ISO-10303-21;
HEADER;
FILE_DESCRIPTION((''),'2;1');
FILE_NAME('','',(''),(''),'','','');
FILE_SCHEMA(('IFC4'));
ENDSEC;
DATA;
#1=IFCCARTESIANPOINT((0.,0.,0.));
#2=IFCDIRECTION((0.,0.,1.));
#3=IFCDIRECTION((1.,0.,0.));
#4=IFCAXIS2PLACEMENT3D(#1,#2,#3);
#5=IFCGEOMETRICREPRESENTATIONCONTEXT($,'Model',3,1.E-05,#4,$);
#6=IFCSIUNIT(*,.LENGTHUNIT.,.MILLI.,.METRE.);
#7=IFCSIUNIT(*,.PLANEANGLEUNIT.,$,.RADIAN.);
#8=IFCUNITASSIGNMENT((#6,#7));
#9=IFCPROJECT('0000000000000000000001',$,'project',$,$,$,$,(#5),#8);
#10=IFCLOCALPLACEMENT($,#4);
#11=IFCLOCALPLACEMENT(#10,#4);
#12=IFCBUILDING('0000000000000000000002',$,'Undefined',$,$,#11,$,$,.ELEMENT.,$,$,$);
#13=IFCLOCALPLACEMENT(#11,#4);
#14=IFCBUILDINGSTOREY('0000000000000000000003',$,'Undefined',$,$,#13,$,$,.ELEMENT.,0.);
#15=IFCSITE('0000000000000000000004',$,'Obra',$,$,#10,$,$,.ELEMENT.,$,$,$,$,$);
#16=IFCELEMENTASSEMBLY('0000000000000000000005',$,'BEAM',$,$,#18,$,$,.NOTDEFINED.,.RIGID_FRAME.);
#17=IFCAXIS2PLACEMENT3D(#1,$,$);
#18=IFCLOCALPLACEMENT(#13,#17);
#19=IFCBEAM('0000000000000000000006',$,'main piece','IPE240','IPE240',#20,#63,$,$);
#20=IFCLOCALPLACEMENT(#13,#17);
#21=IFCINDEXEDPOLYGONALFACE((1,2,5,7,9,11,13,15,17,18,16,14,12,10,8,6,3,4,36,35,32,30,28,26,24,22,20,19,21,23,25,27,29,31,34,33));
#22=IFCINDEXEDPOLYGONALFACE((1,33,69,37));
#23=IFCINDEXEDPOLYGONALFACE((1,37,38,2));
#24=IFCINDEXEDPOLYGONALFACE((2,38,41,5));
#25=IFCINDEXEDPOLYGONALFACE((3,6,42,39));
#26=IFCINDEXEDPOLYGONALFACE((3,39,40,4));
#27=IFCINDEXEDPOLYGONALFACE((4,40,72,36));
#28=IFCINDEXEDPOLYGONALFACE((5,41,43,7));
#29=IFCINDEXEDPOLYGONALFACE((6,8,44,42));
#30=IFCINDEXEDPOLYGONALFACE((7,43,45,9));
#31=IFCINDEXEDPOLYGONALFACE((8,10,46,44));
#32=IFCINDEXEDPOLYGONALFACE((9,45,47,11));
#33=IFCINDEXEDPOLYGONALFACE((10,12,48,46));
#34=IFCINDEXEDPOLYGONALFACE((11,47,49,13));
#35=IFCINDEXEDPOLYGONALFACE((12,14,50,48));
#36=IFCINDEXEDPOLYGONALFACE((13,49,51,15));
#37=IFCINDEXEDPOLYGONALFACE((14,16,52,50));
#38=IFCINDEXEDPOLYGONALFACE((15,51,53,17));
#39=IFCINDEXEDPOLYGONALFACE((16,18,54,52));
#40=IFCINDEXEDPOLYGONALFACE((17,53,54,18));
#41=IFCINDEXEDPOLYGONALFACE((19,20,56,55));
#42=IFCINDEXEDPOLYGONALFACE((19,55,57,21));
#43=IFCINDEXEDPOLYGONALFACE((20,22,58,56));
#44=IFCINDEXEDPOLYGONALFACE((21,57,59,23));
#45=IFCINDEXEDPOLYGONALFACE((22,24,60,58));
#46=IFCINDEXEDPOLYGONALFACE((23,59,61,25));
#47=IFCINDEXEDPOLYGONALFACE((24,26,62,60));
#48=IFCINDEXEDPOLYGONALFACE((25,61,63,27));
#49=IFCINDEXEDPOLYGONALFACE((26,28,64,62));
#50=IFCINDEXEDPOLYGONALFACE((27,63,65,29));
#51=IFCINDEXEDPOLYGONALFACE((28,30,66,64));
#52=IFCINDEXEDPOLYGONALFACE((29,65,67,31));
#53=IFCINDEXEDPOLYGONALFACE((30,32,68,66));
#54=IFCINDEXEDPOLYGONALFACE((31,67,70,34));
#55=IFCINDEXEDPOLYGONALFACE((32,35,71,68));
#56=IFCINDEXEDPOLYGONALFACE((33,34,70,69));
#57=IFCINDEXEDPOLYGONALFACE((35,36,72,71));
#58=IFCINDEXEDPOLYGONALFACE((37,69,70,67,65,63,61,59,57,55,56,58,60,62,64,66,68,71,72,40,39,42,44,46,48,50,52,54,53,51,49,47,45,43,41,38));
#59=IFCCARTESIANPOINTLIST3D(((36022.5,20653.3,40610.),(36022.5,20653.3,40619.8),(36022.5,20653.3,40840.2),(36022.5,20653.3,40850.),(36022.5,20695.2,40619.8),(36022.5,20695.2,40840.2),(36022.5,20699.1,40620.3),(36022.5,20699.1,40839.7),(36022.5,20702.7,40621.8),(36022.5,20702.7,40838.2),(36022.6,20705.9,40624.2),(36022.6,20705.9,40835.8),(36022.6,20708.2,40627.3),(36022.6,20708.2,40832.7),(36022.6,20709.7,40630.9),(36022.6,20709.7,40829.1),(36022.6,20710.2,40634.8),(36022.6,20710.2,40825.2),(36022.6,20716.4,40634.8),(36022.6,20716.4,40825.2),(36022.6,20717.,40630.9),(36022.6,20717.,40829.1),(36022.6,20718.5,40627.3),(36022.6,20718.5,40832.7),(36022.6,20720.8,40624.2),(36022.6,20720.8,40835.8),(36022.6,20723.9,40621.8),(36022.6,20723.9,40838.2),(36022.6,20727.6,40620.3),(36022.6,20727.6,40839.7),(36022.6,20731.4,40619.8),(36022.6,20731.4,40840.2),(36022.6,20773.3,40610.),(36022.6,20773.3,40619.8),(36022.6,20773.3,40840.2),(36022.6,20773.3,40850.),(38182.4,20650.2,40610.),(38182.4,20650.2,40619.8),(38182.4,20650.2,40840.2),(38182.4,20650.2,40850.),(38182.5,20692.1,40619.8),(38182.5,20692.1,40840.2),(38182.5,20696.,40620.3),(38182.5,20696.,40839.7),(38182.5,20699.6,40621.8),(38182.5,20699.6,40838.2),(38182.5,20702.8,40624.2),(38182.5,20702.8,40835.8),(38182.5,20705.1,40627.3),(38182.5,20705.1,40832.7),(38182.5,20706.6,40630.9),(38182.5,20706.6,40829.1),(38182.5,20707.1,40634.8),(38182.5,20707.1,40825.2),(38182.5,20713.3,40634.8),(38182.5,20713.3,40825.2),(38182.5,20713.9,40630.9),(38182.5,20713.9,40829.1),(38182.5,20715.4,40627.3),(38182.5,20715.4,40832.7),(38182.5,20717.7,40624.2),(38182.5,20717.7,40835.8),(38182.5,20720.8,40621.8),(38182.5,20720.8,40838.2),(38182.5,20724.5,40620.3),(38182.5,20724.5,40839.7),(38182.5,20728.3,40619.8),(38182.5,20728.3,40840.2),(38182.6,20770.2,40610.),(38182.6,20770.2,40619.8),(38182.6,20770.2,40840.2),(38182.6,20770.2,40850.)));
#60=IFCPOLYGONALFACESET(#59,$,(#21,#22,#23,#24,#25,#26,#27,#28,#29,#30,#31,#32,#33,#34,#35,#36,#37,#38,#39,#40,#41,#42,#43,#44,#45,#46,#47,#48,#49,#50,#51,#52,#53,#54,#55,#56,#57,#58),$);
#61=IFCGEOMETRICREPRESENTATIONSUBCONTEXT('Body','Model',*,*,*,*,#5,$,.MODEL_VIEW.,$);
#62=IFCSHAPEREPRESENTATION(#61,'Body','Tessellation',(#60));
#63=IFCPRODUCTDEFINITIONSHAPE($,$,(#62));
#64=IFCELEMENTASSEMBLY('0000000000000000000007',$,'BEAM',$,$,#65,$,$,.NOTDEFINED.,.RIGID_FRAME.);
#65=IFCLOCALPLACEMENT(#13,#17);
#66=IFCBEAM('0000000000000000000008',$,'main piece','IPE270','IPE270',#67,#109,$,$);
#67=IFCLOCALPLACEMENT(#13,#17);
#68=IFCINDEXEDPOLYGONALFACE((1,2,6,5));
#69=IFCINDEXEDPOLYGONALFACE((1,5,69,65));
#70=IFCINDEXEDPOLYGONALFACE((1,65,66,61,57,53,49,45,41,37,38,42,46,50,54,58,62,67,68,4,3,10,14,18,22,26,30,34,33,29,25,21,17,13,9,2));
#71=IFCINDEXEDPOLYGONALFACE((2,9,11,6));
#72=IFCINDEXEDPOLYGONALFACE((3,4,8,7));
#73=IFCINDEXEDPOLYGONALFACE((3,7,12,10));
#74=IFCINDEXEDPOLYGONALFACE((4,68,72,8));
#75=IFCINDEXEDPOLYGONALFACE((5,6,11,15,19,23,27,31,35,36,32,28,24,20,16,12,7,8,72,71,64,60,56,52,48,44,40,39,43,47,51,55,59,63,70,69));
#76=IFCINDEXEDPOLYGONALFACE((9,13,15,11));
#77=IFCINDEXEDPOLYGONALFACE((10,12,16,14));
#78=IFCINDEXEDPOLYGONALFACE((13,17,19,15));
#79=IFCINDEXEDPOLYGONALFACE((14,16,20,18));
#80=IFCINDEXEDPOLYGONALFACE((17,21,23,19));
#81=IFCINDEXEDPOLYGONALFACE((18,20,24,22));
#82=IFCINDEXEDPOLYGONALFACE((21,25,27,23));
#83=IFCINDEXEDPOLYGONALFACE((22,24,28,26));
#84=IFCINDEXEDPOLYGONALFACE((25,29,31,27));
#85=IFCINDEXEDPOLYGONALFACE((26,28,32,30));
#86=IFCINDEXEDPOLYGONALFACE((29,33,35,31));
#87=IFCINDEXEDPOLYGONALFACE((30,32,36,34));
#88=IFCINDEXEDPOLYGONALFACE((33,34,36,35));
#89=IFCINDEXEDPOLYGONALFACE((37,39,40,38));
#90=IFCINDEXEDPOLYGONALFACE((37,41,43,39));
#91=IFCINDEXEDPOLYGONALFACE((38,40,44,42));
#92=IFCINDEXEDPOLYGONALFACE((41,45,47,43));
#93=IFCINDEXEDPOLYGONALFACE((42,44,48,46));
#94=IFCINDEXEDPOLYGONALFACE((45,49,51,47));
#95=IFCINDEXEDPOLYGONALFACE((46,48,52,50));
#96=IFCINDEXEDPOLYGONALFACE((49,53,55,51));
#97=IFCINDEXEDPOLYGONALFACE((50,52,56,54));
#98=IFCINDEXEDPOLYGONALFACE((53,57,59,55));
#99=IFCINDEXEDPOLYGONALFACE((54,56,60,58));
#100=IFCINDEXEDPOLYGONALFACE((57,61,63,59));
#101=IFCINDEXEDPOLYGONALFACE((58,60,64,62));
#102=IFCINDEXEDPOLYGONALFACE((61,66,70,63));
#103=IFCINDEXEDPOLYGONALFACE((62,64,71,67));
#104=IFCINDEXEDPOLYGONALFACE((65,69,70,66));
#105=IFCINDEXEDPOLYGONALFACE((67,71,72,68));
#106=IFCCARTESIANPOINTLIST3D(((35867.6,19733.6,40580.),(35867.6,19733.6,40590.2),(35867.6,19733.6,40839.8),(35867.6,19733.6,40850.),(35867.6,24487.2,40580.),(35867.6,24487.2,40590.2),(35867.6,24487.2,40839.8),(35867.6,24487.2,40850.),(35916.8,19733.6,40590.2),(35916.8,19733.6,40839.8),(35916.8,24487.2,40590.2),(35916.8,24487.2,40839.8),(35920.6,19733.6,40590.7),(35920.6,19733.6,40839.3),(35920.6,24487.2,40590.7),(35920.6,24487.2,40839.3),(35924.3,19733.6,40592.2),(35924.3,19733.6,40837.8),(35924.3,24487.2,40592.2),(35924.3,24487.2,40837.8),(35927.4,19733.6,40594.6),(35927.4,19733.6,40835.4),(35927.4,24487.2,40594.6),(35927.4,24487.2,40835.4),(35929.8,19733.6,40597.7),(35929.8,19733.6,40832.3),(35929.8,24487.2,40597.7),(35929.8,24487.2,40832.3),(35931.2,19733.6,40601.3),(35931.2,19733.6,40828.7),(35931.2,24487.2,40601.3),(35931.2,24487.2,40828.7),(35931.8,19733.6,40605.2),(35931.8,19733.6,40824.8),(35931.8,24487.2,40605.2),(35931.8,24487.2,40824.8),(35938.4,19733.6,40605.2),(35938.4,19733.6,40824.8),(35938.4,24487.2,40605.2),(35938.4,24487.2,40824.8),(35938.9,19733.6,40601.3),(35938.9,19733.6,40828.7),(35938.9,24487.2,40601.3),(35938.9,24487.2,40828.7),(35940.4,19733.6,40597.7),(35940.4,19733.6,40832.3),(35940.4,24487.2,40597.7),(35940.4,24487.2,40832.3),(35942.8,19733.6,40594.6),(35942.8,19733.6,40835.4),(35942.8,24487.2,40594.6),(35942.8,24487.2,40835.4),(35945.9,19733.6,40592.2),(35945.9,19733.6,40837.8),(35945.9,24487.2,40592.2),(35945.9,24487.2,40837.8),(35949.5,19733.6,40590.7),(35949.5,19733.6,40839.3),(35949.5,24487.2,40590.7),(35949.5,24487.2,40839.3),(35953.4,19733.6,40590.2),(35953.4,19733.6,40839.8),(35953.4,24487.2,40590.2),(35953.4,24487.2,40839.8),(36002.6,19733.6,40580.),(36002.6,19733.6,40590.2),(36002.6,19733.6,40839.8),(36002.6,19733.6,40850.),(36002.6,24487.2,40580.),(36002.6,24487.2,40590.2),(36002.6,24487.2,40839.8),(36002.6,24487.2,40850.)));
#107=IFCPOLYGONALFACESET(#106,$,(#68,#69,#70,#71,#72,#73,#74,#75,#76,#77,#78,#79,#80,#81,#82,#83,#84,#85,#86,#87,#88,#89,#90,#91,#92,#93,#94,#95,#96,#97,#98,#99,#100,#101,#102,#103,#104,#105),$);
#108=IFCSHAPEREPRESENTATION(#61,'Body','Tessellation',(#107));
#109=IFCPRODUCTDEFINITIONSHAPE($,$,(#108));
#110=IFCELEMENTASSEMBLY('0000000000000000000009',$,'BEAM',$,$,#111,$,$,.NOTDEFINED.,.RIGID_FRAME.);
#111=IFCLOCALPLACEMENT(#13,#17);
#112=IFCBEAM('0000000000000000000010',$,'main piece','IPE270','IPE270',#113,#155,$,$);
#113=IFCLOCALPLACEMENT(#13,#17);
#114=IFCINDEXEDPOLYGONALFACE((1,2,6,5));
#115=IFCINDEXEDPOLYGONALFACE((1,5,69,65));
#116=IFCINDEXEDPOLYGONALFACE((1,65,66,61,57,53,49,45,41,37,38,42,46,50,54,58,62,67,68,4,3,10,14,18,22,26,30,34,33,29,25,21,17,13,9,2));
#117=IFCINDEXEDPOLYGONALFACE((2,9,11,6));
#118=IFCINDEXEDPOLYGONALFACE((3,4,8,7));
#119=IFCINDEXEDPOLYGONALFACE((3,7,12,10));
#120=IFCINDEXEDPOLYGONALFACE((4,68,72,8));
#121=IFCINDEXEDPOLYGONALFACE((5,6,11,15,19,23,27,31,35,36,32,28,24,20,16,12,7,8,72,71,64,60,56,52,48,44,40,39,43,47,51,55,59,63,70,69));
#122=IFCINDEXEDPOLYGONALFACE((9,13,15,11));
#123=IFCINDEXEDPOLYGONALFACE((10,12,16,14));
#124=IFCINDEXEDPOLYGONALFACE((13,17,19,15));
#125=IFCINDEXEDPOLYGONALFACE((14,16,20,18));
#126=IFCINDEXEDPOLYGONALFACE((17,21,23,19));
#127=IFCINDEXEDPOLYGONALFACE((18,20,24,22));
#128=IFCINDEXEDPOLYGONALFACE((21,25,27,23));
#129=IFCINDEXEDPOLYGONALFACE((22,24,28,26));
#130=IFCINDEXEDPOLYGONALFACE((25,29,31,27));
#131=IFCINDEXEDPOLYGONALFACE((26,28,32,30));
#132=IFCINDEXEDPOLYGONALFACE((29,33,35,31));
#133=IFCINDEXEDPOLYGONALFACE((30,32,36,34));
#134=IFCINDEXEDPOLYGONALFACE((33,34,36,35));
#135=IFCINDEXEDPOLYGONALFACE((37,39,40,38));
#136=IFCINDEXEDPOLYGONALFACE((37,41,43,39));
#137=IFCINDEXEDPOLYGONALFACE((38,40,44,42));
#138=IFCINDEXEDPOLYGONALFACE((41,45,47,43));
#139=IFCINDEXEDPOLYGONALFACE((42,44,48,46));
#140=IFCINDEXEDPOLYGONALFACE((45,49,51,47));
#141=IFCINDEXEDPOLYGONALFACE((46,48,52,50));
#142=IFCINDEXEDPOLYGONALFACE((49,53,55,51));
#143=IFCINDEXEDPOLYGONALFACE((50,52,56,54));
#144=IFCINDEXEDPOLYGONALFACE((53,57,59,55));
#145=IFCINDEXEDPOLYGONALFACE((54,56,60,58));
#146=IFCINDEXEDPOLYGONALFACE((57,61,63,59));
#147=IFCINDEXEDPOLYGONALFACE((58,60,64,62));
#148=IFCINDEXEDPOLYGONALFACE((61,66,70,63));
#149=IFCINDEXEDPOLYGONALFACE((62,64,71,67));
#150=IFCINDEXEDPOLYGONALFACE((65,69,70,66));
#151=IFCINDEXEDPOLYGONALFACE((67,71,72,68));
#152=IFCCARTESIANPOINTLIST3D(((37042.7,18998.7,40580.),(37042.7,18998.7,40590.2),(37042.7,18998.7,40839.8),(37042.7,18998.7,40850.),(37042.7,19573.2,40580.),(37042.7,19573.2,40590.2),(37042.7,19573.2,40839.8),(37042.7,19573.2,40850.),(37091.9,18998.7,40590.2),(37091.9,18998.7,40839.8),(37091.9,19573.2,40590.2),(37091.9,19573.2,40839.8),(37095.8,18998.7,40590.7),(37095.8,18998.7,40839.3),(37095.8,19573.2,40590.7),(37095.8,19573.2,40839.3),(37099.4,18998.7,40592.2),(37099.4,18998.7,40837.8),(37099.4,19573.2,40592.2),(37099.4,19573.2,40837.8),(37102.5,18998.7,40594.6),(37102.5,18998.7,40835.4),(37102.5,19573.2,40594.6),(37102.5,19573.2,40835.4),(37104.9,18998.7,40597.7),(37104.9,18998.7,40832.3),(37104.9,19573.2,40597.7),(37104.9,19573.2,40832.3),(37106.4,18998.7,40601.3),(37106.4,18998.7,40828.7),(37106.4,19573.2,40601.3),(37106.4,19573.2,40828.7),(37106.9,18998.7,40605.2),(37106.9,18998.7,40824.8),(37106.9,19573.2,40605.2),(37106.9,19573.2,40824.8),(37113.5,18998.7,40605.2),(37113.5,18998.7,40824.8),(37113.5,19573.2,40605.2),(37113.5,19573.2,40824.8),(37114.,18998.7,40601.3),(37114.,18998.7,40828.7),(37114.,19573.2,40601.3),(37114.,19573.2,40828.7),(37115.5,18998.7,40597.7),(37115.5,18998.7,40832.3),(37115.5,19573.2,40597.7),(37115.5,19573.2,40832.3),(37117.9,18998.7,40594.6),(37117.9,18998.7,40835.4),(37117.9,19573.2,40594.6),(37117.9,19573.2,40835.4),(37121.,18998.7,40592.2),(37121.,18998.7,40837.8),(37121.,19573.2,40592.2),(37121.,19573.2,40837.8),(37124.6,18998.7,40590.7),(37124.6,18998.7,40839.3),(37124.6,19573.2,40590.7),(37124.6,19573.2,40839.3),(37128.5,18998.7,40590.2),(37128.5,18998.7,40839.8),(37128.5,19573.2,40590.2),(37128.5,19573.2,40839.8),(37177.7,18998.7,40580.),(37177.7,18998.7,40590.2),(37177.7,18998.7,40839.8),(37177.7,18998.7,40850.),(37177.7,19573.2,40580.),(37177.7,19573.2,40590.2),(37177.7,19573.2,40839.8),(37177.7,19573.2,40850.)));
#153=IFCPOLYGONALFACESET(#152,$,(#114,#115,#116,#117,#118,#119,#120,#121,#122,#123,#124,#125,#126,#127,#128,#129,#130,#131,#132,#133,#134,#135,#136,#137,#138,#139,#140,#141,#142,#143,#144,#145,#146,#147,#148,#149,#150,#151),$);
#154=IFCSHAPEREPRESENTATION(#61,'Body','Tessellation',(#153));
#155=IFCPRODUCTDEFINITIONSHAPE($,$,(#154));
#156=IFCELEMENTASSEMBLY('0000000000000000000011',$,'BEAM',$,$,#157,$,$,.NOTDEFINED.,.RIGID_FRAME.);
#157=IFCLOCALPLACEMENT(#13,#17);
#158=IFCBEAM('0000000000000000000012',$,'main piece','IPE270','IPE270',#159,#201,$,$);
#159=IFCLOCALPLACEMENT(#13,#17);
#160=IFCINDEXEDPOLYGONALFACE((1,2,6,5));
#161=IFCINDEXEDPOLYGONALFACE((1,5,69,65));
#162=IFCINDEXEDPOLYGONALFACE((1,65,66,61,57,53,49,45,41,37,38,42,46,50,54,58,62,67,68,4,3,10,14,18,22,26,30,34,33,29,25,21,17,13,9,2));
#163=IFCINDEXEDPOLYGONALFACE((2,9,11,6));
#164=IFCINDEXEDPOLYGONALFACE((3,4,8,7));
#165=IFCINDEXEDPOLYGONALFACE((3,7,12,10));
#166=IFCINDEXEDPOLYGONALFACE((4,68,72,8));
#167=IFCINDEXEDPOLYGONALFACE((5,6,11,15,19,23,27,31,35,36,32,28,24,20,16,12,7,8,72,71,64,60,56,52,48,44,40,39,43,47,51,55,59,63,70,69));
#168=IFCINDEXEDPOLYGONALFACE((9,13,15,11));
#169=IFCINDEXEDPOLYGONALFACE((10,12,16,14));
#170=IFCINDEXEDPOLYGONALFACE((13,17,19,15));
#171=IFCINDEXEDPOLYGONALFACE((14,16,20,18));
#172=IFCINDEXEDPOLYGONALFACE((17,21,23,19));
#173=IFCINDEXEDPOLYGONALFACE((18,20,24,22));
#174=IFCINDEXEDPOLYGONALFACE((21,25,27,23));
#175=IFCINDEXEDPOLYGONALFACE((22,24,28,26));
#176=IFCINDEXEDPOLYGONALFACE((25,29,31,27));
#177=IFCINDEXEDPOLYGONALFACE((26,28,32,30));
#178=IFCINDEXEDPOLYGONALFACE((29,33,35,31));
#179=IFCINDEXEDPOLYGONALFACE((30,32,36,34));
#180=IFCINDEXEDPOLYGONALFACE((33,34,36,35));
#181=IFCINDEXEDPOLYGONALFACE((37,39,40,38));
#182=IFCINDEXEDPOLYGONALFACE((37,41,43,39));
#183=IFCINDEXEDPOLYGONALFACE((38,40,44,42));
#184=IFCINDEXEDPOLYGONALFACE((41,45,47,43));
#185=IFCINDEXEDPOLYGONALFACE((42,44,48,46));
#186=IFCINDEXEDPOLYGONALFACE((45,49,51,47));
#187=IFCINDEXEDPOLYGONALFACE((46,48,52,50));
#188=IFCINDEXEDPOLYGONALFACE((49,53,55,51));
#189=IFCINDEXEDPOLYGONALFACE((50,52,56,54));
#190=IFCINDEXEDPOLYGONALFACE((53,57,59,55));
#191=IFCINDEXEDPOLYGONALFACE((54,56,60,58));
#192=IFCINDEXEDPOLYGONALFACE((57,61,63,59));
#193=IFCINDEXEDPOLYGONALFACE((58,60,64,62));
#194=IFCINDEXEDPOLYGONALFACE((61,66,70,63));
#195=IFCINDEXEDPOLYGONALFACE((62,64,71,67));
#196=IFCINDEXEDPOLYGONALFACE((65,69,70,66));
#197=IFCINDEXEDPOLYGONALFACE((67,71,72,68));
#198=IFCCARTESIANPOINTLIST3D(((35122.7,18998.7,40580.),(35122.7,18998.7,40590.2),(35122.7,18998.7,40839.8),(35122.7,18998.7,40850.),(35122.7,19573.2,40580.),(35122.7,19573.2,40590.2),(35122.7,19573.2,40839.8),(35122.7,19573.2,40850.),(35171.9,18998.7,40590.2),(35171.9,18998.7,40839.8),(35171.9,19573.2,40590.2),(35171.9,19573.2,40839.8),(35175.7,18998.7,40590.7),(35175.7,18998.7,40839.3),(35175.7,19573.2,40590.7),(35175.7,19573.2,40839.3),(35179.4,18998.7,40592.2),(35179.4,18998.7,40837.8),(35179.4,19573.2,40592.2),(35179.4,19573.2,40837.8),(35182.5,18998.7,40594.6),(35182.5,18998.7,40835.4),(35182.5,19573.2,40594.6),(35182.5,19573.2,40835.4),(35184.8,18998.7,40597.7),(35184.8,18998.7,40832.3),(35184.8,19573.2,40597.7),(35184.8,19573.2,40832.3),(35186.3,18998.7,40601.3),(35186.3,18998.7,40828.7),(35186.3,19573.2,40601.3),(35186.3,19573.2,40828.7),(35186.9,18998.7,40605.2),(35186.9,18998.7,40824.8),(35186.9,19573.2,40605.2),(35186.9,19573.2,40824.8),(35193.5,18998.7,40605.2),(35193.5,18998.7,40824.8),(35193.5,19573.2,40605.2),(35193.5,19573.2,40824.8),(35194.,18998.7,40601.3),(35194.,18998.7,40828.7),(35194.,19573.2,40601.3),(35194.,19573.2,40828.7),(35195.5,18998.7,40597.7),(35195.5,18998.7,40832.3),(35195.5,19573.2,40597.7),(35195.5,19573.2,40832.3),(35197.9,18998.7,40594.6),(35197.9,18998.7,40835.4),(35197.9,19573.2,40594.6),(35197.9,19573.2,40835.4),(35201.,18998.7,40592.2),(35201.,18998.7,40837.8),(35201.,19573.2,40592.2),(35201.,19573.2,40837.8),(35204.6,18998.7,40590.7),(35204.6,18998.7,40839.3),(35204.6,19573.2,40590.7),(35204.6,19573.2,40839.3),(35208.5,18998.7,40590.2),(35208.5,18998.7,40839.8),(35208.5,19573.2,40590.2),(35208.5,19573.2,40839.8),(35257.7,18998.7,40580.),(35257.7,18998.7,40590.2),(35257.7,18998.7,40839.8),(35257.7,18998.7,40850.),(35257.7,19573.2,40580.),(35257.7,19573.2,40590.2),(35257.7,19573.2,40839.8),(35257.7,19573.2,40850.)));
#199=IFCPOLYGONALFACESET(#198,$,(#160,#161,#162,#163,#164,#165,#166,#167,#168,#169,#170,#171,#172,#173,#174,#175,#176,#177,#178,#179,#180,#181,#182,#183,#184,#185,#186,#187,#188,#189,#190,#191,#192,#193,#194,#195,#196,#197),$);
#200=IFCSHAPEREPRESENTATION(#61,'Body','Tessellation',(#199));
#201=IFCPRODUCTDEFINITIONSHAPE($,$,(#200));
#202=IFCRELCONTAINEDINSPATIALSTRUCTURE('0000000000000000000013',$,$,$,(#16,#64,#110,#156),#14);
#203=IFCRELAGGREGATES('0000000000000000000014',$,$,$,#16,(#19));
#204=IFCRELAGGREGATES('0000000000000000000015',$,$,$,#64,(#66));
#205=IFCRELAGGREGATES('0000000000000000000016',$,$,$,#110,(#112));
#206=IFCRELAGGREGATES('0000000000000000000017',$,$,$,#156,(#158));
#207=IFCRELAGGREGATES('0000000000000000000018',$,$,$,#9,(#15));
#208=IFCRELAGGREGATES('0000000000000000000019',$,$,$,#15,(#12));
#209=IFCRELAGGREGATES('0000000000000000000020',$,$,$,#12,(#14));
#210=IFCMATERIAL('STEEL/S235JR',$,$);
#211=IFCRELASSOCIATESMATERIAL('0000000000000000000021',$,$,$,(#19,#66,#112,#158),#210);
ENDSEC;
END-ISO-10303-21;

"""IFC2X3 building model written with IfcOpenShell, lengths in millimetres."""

from ifc_helpers import new_model, si_unit, frame, origin_with_axes, origin_2d_with_axis, place, context, subcontext, project, spatial, i_section, extrude, material, element, aggregate, save


model = new_model("IFC2X3")

# Units and contexts
model_context = context("Model", 3, precision=1e-05, world=origin_with_axes())
body_context = subcontext(model_context, "Body", "Model", "MODEL_VIEW")
ifc_project = project(units=[si_unit("LENGTHUNIT", "METRE", prefix="MILLI"), si_unit("PLANEANGLEUNIT", "RADIAN")], contexts=[model_context])

# Site, building, storey
site_placement = place(None, origin_with_axes())
site = spatial("IfcSite", under=ifc_project, at=site_placement, Name="Obra", CompositionType="ELEMENT")
building_placement = place(site_placement, origin_with_axes())
building = spatial("IfcBuilding", under=site, at=building_placement, Name="Undefined", CompositionType="ELEMENT")
storey_placement = place(building_placement, origin_with_axes())
storey = spatial("IfcBuildingStorey", under=building, at=storey_placement, Name="Undefined", CompositionType="ELEMENT", Elevation=0.0)

# Element assemblies, beams
ifc_material_1 = material(Name="STEEL/S235JR")
assembly_1_placement = place(storey_placement, origin_with_axes())
assembly_1 = element("IfcElementAssembly", 1, at=assembly_1_placement, inside=storey, Name="BEAM", AssemblyPlace="NOTDEFINED", PredefinedType="RIGID_FRAME")
beam_1_placement = place(assembly_1_placement, frame((36022.6, 20713.3, 40730.0), z_axis=(0.0, 0.0, 1.0), x_axis=(0.999999, -0.001435, 0.0)))
beam_1 = element("IfcBeam", 2, at=beam_1_placement, material=ifc_material_1, Name="main piece", Description="IPE240", ObjectType="IPE240", context=body_context, shape_type="SweptSolid", body=[
    extrude(i_section(OverallWidth=120.0, OverallDepth=240.0, WebThickness=6.2, FlangeThickness=9.8, FilletRadius=15.0, at=origin_2d_with_axis()), frame((2159.9, 0.0, 0.0), z_axis=(-1.0, 0.0, 0.0), x_axis=(0.0, -1.0, 0.0)), (0.0, 0.0, 1.0), 2159.9),
])
aggregate(assembly_1, [beam_1])
assembly_2_placement = place(storey_placement, origin_with_axes())
assembly_2 = element("IfcElementAssembly", 3, at=assembly_2_placement, inside=storey, Name="BEAM", AssemblyPlace="NOTDEFINED", PredefinedType="RIGID_FRAME")
beam_2_placement = place(assembly_2_placement, frame((35935.1, 19733.6, 40715.0), z_axis=(0.0, 0.0, 1.0), x_axis=(0.0, 1.0, 0.0)))
beam_2 = element("IfcBeam", 4, at=beam_2_placement, material=ifc_material_1, Name="main piece", Description="IPE270", ObjectType="IPE270", context=body_context, shape_type="SweptSolid", body=[
    extrude(i_section(OverallWidth=135.0, OverallDepth=270.0, WebThickness=6.6, FlangeThickness=10.2, FilletRadius=15.0, at=origin_2d_with_axis()), frame((4753.6, 0.0, 0.0), z_axis=(-1.0, 0.0, 0.0), x_axis=(0.0, -1.0, 0.0)), (0.0, 0.0, 1.0), 4753.6),
])
aggregate(assembly_2, [beam_2])
assembly_3_placement = place(storey_placement, origin_with_axes())
assembly_3 = element("IfcElementAssembly", 5, at=assembly_3_placement, inside=storey, Name="BEAM", AssemblyPlace="NOTDEFINED", PredefinedType="RIGID_FRAME")
beam_3_placement = place(assembly_3_placement, frame((37110.2, 18998.7, 40715.0), z_axis=(0.0, 0.0, 1.0), x_axis=(0.0, 1.0, 0.0)))
beam_3 = element("IfcBeam", 6, at=beam_3_placement, material=ifc_material_1, Name="main piece", Description="IPE270", ObjectType="IPE270", context=body_context, shape_type="SweptSolid", body=[
    extrude(i_section(OverallWidth=135.0, OverallDepth=270.0, WebThickness=6.6, FlangeThickness=10.2, FilletRadius=15.0, at=origin_2d_with_axis()), frame((574.5, 0.0, 0.0), z_axis=(-1.0, 0.0, 0.0), x_axis=(0.0, -1.0, 0.0)), (0.0, 0.0, 1.0), 574.5),
])
aggregate(assembly_3, [beam_3])
assembly_4_placement = place(storey_placement, origin_with_axes())
assembly_4 = element("IfcElementAssembly", 7, at=assembly_4_placement, inside=storey, Name="BEAM", AssemblyPlace="NOTDEFINED", PredefinedType="RIGID_FRAME")
beam_4_placement = place(assembly_4_placement, frame((35190.2, 18998.7, 40715.0), z_axis=(0.0, 0.0, 1.0), x_axis=(0.0, 1.0, 0.0)))
beam_4 = element("IfcBeam", 8, at=beam_4_placement, material=ifc_material_1, Name="main piece", Description="IPE270", ObjectType="IPE270", context=body_context, shape_type="SweptSolid", body=[
    extrude(i_section(OverallWidth=135.0, OverallDepth=270.0, WebThickness=6.6, FlangeThickness=10.2, FilletRadius=15.0, at=origin_2d_with_axis()), frame((574.5, 0.0, 0.0), z_axis=(-1.0, 0.0, 0.0), x_axis=(0.0, -1.0, 0.0)), (0.0, 0.0, 1.0), 574.5),
])
aggregate(assembly_4, [beam_4])

save(model, "model.ifc")
